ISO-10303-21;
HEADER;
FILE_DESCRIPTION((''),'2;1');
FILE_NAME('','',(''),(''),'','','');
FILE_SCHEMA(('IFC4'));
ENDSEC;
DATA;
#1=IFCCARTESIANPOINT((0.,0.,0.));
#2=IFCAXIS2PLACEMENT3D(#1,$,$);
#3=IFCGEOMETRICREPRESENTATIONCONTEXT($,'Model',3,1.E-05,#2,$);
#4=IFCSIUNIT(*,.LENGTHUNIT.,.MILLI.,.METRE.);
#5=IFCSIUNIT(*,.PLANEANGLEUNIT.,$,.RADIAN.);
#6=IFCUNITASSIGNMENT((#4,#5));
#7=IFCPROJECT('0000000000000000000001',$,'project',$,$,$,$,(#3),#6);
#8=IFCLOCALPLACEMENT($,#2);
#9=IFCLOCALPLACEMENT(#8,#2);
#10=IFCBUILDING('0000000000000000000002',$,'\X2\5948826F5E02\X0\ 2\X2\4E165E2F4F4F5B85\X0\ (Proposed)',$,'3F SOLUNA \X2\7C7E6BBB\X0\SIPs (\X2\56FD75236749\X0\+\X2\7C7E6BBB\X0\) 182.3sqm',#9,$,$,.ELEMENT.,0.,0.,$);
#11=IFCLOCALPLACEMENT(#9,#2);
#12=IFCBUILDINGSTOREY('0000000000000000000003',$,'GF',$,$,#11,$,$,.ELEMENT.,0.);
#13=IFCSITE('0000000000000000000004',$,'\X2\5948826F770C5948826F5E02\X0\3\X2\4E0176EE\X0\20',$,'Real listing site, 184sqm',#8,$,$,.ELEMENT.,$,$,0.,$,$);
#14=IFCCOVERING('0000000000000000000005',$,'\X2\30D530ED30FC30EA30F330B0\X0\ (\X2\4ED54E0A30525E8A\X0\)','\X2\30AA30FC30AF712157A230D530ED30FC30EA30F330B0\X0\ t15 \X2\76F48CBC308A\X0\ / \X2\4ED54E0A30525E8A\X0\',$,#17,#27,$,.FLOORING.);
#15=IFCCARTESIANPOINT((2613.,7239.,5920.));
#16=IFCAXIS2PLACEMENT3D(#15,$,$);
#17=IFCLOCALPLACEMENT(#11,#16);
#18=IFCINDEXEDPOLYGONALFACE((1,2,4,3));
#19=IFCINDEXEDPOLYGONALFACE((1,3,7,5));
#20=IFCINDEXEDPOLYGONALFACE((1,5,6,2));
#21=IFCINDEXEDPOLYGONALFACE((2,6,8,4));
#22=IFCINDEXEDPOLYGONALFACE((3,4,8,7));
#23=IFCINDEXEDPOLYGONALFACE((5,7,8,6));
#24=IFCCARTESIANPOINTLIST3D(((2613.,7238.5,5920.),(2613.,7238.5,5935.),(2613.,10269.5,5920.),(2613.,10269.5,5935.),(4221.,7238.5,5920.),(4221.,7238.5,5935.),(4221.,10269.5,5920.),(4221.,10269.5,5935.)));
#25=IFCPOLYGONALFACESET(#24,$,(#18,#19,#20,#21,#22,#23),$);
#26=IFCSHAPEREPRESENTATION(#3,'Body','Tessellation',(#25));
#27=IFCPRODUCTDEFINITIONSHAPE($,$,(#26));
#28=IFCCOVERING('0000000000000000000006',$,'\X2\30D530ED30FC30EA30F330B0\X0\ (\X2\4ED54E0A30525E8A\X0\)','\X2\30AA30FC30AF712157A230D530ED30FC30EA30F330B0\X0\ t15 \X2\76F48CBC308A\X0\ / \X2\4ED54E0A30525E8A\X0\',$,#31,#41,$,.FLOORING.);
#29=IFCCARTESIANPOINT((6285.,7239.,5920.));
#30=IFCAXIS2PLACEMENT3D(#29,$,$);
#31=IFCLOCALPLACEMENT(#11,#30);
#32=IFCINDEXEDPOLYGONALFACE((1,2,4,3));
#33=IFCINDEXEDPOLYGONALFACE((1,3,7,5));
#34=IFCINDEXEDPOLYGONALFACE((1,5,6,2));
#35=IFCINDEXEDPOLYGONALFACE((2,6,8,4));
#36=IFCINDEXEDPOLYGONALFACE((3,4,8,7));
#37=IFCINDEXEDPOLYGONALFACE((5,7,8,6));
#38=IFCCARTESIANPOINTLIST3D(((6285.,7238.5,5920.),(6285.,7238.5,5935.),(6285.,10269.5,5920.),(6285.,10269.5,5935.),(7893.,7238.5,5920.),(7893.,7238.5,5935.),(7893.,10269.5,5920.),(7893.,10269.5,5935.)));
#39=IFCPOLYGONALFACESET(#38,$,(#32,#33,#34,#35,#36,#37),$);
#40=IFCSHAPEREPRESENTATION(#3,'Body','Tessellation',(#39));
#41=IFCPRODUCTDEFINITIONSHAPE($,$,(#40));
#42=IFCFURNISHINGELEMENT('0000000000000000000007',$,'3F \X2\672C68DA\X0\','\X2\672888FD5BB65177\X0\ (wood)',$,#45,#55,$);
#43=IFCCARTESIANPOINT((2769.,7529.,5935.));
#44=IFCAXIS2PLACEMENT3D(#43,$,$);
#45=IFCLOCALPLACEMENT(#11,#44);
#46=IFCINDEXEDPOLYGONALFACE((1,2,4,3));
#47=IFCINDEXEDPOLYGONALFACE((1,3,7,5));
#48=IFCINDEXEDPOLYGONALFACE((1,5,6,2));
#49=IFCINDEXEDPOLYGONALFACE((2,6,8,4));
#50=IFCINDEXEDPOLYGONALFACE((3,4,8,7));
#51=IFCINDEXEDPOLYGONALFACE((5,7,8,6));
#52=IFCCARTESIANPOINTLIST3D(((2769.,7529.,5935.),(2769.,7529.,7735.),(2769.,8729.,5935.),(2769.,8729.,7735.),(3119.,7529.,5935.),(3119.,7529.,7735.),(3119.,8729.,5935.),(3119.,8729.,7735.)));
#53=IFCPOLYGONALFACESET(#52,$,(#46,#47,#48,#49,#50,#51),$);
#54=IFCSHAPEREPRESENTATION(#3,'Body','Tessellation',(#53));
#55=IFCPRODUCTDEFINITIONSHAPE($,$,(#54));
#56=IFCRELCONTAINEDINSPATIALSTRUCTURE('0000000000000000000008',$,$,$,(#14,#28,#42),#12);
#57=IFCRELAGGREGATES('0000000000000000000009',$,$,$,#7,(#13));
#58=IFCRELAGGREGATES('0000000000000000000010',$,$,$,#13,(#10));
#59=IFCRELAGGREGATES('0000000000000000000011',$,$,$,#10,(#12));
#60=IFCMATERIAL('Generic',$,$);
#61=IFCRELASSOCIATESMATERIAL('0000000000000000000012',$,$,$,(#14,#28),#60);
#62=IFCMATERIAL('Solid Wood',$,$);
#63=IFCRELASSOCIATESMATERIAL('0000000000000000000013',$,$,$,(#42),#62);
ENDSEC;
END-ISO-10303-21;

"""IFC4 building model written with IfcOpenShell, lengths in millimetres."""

from ifc_helpers import new_model, si_unit, frame, frame_2d, origin, place, context, project, spatial, rectangle, extrude, material, element, save


model = new_model("IFC4")

# Units and contexts
model_context = context("Model", 3, precision=1e-05, world=origin())
ifc_project = project(units=[si_unit("LENGTHUNIT", "METRE", prefix="MILLI"), si_unit("PLANEANGLEUNIT", "RADIAN")], contexts=[model_context])

# Site, building, storey
site_placement = place(None, origin())
site = spatial("IfcSite", under=ifc_project, at=site_placement, Name="奈良県奈良市3丁目20", ObjectType="Real listing site, 184sqm", CompositionType="ELEMENT", RefElevation=0.0)
building_placement = place(site_placement, origin())
building = spatial("IfcBuilding", under=site, at=building_placement, Name="奈良市 2世帯住宅 (Proposed)", ObjectType="3F SOLUNA 籾殻SIPs (国産杉+籾殻) 182.3sqm", CompositionType="ELEMENT", ElevationOfRefHeight=0.0, ElevationOfTerrain=0.0)
storey_placement = place(building_placement, origin())
storey = spatial("IfcBuildingStorey", under=building, at=storey_placement, Name="GF", CompositionType="ELEMENT", Elevation=0.0)

# Shared definitions
ifc_material_1 = material(Name="Solid Wood")

# Shared definitions
ifc_material_2 = material(Name="Generic")

# Coverings
covering_1_placement = place(storey_placement, frame((2613.0, 7239.0, 5920.0)))
element("IfcCovering", 1, at=covering_1_placement, inside=storey, material=ifc_material_2, Name="フローリング (仕上げ床)", Description="オーク無垢フローリング t15 直貼り / 仕上げ床", PredefinedType="FLOORING", context=model_context, shape_type="SweptSolid", body=[
    extrude(rectangle(XDim=1608.0, YDim=3031.0, at=frame_2d((804.0, 1515.0))), frame((2613.0, 7239.0, 5920.0)), (0.0, 0.0, 1.0), 15.0),
])
covering_2_placement = place(storey_placement, frame((6285.0, 7239.0, 5920.0)))
element("IfcCovering", 2, at=covering_2_placement, inside=storey, material=ifc_material_2, Name="フローリング (仕上げ床)", Description="オーク無垢フローリング t15 直貼り / 仕上げ床", PredefinedType="FLOORING", context=model_context, shape_type="SweptSolid", body=[
    extrude(rectangle(XDim=1608.0, YDim=3031.0, at=frame_2d((804.0, 1515.0))), frame((6285.0, 7239.0, 5920.0)), (0.0, 0.0, 1.0), 15.0),
])

# Furnishing element
furnishing_placement = place(storey_placement, frame((2769.0, 7529.0, 5935.0)))
element("IfcFurnishingElement", 3, at=furnishing_placement, inside=storey, material=ifc_material_1, Name="3F 本棚", Description="木製家具 (wood)", context=model_context, shape_type="SweptSolid", body=[
    extrude(rectangle(XDim=350.0, YDim=1200.0, at=frame_2d((175.0, 600.0))), frame((2769.0, 7529.0, 5935.0)), (0.0, 0.0, 1.0), 1800.0),
])

save(model, "model.ifc")
